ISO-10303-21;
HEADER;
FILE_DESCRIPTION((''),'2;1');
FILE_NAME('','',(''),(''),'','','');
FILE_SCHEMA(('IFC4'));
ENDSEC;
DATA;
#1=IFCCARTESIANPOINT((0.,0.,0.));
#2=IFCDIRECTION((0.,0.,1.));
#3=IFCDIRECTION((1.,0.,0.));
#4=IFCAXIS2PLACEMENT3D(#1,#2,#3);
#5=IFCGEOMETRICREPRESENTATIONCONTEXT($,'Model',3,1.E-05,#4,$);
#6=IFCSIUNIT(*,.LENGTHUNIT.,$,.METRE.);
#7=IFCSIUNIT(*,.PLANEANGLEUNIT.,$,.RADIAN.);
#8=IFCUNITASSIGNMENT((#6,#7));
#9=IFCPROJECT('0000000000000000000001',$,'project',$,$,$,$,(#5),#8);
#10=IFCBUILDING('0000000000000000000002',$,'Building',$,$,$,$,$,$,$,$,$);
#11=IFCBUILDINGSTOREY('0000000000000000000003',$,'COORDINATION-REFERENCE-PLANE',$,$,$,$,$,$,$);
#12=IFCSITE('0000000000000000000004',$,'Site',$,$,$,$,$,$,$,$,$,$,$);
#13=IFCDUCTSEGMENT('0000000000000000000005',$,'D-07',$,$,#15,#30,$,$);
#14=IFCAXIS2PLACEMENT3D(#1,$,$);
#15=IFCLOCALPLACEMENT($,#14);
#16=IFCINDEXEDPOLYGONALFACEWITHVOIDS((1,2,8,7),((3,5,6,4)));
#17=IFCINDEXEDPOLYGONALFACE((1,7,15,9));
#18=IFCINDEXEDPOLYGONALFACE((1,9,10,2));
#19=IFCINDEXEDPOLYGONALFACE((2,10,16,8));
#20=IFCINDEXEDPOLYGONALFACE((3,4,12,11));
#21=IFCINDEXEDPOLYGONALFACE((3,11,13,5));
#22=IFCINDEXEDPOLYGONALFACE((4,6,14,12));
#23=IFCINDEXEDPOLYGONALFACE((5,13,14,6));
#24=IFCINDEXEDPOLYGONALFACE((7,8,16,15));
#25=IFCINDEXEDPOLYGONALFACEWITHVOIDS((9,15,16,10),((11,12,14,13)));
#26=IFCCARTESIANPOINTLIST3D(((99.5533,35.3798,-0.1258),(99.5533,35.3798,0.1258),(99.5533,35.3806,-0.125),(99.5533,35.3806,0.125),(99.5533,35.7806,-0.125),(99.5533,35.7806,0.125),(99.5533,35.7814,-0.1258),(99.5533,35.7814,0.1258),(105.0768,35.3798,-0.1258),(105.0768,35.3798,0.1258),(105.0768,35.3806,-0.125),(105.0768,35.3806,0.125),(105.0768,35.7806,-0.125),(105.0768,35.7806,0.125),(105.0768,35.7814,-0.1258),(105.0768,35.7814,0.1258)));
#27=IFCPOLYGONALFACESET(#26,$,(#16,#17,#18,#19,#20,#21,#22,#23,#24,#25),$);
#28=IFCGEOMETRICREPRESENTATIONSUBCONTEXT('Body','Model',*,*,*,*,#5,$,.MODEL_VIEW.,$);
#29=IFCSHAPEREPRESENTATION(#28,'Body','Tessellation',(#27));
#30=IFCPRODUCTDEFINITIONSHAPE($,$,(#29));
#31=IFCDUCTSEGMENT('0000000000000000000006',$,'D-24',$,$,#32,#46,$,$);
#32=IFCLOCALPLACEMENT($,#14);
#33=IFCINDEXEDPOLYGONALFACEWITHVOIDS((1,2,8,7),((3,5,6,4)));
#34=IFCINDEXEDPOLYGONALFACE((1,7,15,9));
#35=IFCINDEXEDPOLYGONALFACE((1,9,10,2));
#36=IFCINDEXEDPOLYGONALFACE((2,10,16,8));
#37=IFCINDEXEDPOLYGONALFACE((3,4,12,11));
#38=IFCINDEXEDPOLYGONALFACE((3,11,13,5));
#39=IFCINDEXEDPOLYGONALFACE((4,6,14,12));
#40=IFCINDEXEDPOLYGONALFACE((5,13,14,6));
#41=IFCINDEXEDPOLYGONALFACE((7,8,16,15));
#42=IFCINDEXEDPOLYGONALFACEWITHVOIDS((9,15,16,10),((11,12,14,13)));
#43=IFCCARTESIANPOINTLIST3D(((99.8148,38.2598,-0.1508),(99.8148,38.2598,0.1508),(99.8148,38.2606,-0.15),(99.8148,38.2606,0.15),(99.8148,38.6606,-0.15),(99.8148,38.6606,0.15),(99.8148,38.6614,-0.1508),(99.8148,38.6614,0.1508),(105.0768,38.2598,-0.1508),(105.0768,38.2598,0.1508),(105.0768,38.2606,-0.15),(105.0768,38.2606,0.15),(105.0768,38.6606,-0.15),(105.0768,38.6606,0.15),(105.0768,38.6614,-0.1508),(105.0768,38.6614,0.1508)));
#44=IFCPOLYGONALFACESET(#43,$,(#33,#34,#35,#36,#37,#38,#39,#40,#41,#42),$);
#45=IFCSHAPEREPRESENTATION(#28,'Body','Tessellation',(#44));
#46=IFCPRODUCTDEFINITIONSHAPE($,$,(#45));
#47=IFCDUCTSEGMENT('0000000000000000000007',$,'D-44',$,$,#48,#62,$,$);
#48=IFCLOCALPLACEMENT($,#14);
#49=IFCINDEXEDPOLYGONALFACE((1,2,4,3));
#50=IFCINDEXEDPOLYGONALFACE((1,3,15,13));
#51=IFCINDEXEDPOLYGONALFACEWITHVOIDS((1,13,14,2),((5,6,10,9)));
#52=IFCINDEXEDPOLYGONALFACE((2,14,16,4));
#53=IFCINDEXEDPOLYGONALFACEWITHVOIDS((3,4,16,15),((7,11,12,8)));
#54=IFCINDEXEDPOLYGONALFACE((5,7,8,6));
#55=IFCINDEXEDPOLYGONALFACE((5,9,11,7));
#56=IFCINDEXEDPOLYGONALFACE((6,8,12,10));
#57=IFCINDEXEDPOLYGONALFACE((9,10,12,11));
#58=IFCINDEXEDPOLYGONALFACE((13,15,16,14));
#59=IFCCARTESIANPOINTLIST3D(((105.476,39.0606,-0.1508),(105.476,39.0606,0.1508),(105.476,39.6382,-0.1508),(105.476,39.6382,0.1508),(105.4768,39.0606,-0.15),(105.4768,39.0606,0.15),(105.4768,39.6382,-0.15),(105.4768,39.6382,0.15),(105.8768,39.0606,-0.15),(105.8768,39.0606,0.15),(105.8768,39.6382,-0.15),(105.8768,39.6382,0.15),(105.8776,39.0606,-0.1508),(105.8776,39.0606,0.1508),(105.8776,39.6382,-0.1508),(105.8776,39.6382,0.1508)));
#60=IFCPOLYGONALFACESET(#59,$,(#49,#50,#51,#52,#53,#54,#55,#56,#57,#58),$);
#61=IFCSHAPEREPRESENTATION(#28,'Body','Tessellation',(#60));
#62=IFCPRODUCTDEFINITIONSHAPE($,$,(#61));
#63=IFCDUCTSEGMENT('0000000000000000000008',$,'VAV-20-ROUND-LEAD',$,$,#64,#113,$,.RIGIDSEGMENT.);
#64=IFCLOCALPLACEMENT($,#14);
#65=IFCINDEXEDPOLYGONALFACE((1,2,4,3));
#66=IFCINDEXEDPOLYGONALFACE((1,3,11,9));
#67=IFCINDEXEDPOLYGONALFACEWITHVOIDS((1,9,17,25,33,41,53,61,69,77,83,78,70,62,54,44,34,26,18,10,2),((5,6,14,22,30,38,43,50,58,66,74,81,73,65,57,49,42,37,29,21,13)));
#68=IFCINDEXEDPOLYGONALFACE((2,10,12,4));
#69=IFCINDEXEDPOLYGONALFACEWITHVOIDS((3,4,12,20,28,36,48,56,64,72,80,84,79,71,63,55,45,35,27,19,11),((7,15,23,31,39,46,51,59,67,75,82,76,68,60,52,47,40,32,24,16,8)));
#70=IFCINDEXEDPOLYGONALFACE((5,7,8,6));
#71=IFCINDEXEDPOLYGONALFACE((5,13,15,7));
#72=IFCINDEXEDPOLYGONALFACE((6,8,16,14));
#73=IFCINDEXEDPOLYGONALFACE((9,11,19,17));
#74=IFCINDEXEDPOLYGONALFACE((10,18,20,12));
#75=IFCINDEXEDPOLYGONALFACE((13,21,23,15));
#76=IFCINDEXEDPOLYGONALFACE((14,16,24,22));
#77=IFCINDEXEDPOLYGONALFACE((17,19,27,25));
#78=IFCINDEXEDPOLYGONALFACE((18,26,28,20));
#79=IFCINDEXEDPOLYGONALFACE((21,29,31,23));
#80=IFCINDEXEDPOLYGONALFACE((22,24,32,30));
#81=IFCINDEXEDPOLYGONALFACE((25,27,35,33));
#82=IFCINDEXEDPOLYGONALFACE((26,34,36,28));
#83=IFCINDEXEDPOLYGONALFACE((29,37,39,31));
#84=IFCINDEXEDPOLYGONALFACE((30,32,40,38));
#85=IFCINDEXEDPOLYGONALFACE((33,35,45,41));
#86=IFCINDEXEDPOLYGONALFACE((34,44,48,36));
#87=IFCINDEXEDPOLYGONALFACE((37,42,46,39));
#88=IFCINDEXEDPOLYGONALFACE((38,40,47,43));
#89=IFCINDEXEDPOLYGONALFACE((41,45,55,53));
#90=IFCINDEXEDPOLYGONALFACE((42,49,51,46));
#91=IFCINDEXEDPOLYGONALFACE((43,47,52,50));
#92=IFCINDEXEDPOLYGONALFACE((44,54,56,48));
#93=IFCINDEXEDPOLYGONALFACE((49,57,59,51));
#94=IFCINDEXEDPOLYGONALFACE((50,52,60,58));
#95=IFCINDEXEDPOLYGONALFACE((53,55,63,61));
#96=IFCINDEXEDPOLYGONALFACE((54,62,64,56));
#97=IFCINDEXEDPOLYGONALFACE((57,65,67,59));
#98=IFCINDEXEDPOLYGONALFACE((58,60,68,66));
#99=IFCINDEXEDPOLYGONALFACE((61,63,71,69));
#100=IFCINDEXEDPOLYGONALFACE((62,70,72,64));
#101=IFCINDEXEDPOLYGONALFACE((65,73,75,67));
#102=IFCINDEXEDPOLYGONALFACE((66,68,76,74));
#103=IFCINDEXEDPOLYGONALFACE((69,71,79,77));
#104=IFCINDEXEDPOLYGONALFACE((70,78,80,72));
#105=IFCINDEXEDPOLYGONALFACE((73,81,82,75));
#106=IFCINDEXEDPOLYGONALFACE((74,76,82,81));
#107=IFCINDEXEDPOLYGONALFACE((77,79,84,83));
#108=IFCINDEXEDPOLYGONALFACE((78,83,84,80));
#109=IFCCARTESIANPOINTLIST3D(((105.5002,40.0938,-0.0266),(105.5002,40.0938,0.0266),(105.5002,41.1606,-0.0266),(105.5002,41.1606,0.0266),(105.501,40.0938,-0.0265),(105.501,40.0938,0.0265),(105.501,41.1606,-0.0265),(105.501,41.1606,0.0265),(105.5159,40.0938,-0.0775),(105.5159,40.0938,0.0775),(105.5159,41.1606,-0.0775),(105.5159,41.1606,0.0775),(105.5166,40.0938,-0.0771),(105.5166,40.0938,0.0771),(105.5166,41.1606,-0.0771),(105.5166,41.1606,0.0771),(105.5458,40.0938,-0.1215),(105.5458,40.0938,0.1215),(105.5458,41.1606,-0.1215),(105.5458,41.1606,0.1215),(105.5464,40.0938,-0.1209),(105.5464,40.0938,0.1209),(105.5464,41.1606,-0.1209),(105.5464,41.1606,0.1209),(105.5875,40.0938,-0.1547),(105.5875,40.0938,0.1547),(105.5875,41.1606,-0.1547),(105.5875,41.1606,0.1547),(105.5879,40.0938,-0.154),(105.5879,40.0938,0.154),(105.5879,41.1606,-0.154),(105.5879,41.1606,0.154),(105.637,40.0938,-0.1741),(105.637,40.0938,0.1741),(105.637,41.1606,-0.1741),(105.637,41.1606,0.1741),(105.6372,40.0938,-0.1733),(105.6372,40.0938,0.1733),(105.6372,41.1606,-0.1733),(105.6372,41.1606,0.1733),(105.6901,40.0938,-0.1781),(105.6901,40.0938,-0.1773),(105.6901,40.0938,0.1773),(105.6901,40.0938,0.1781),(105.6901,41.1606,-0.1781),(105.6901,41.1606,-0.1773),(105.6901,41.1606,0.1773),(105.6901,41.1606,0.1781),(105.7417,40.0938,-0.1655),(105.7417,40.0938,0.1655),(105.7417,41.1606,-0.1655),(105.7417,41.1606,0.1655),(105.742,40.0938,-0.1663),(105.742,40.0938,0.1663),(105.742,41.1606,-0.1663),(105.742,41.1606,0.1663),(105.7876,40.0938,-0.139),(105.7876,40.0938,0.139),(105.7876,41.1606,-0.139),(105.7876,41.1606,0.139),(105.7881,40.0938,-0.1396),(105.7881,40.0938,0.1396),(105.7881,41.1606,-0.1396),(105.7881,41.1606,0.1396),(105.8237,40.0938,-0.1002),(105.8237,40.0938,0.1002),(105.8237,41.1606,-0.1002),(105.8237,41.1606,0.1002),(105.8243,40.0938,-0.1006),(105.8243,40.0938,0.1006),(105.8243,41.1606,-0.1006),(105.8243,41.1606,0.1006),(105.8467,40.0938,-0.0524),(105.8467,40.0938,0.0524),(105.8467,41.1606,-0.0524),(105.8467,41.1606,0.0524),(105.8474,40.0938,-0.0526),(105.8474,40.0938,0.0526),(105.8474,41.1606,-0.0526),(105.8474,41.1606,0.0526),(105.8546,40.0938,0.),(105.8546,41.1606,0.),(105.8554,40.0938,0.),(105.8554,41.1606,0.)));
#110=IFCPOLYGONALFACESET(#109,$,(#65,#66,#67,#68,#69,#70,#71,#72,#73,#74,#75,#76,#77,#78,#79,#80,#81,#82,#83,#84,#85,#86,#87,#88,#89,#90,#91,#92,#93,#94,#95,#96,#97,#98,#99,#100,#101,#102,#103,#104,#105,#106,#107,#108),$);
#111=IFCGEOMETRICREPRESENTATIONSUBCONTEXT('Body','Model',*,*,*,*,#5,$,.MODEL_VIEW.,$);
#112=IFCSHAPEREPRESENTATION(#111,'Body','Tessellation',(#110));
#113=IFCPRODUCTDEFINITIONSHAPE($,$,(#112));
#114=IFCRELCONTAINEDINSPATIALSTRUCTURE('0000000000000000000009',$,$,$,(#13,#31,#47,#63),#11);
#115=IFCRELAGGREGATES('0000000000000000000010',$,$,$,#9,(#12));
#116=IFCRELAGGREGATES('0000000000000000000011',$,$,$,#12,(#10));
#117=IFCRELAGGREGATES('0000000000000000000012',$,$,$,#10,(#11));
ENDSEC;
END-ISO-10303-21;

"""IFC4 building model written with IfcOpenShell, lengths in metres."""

from ifc_helpers import new_model, si_unit, frame, origin, origin_with_axes, place, context, subcontext, project, spatial, hollow_rectangle, hollow_circle, extrude, element, save


model = new_model("IFC4")

# Units and contexts
model_context = context("Model", 3, precision=1e-05, world=origin_with_axes())
body_context_1 = subcontext(model_context, "Body", "Model", "MODEL_VIEW")
body_context_2 = subcontext(model_context, "Body", "Model", "MODEL_VIEW")
ifc_project = project(units=[si_unit("LENGTHUNIT", "METRE"), si_unit("PLANEANGLEUNIT", "RADIAN")], contexts=[model_context])

# Site, building, storey
site = spatial("IfcSite", under=ifc_project, Name="Site")
building = spatial("IfcBuilding", under=site, Name="Building")
storey = spatial("IfcBuildingStorey", under=building, Name="COORDINATION-REFERENCE-PLANE")

# Duct segments
duct_segment_1_placement = place(None, frame((99.5533, 35.5806, 0.0), z_axis=(1.0, 0.0, 0.0), x_axis=(0.0, 1.0, 0.0)))
element("IfcDuctSegment", 1, at=duct_segment_1_placement, inside=storey, Name="D-07", context=body_context_1, shape_type="SweptSolid", body=[
    extrude(hollow_rectangle(XDim=0.4016, YDim=0.2516, WallThickness=0.0008), origin(), (0.0, 0.0, 1.0), 5.5234),
])
duct_segment_2_placement = place(None, frame((99.8148, 38.4606, 0.0), z_axis=(1.0, 0.0, 0.0), x_axis=(0.0, 1.0, 0.0)))
element("IfcDuctSegment", 2, at=duct_segment_2_placement, inside=storey, Name="D-24", context=body_context_1, shape_type="SweptSolid", body=[
    extrude(hollow_rectangle(XDim=0.4016, YDim=0.3016, WallThickness=0.0008), origin(), (0.0, 0.0, 1.0), 5.2619),
])
duct_segment_3_placement = place(None, frame((105.6768, 39.0606, 0.0), z_axis=(0.0, 1.0, 0.0), x_axis=(1.0, 0.0, 0.0)))
element("IfcDuctSegment", 3, at=duct_segment_3_placement, inside=storey, Name="D-44", context=body_context_1, shape_type="SweptSolid", body=[
    extrude(hollow_rectangle(XDim=0.4016, YDim=0.3016, WallThickness=0.0008), origin(), (0.0, 0.0, 1.0), 0.5776),
])

# Duct segment
duct_segment_4_placement = place(None, frame((105.6768, 40.0938, 0.0), z_axis=(0.0, 1.0, 0.0), x_axis=(1.0, 0.0, 0.0)))
element("IfcDuctSegment", 4, at=duct_segment_4_placement, inside=storey, Name="VAV-20-ROUND-LEAD", PredefinedType="RIGIDSEGMENT", context=body_context_2, shape_type="SweptSolid", body=[
    extrude(hollow_circle(Radius=0.1786, WallThickness=0.0008), origin(), (0.0, 0.0, 1.0), 1.0668),
])

save(model, "model.ifc")
